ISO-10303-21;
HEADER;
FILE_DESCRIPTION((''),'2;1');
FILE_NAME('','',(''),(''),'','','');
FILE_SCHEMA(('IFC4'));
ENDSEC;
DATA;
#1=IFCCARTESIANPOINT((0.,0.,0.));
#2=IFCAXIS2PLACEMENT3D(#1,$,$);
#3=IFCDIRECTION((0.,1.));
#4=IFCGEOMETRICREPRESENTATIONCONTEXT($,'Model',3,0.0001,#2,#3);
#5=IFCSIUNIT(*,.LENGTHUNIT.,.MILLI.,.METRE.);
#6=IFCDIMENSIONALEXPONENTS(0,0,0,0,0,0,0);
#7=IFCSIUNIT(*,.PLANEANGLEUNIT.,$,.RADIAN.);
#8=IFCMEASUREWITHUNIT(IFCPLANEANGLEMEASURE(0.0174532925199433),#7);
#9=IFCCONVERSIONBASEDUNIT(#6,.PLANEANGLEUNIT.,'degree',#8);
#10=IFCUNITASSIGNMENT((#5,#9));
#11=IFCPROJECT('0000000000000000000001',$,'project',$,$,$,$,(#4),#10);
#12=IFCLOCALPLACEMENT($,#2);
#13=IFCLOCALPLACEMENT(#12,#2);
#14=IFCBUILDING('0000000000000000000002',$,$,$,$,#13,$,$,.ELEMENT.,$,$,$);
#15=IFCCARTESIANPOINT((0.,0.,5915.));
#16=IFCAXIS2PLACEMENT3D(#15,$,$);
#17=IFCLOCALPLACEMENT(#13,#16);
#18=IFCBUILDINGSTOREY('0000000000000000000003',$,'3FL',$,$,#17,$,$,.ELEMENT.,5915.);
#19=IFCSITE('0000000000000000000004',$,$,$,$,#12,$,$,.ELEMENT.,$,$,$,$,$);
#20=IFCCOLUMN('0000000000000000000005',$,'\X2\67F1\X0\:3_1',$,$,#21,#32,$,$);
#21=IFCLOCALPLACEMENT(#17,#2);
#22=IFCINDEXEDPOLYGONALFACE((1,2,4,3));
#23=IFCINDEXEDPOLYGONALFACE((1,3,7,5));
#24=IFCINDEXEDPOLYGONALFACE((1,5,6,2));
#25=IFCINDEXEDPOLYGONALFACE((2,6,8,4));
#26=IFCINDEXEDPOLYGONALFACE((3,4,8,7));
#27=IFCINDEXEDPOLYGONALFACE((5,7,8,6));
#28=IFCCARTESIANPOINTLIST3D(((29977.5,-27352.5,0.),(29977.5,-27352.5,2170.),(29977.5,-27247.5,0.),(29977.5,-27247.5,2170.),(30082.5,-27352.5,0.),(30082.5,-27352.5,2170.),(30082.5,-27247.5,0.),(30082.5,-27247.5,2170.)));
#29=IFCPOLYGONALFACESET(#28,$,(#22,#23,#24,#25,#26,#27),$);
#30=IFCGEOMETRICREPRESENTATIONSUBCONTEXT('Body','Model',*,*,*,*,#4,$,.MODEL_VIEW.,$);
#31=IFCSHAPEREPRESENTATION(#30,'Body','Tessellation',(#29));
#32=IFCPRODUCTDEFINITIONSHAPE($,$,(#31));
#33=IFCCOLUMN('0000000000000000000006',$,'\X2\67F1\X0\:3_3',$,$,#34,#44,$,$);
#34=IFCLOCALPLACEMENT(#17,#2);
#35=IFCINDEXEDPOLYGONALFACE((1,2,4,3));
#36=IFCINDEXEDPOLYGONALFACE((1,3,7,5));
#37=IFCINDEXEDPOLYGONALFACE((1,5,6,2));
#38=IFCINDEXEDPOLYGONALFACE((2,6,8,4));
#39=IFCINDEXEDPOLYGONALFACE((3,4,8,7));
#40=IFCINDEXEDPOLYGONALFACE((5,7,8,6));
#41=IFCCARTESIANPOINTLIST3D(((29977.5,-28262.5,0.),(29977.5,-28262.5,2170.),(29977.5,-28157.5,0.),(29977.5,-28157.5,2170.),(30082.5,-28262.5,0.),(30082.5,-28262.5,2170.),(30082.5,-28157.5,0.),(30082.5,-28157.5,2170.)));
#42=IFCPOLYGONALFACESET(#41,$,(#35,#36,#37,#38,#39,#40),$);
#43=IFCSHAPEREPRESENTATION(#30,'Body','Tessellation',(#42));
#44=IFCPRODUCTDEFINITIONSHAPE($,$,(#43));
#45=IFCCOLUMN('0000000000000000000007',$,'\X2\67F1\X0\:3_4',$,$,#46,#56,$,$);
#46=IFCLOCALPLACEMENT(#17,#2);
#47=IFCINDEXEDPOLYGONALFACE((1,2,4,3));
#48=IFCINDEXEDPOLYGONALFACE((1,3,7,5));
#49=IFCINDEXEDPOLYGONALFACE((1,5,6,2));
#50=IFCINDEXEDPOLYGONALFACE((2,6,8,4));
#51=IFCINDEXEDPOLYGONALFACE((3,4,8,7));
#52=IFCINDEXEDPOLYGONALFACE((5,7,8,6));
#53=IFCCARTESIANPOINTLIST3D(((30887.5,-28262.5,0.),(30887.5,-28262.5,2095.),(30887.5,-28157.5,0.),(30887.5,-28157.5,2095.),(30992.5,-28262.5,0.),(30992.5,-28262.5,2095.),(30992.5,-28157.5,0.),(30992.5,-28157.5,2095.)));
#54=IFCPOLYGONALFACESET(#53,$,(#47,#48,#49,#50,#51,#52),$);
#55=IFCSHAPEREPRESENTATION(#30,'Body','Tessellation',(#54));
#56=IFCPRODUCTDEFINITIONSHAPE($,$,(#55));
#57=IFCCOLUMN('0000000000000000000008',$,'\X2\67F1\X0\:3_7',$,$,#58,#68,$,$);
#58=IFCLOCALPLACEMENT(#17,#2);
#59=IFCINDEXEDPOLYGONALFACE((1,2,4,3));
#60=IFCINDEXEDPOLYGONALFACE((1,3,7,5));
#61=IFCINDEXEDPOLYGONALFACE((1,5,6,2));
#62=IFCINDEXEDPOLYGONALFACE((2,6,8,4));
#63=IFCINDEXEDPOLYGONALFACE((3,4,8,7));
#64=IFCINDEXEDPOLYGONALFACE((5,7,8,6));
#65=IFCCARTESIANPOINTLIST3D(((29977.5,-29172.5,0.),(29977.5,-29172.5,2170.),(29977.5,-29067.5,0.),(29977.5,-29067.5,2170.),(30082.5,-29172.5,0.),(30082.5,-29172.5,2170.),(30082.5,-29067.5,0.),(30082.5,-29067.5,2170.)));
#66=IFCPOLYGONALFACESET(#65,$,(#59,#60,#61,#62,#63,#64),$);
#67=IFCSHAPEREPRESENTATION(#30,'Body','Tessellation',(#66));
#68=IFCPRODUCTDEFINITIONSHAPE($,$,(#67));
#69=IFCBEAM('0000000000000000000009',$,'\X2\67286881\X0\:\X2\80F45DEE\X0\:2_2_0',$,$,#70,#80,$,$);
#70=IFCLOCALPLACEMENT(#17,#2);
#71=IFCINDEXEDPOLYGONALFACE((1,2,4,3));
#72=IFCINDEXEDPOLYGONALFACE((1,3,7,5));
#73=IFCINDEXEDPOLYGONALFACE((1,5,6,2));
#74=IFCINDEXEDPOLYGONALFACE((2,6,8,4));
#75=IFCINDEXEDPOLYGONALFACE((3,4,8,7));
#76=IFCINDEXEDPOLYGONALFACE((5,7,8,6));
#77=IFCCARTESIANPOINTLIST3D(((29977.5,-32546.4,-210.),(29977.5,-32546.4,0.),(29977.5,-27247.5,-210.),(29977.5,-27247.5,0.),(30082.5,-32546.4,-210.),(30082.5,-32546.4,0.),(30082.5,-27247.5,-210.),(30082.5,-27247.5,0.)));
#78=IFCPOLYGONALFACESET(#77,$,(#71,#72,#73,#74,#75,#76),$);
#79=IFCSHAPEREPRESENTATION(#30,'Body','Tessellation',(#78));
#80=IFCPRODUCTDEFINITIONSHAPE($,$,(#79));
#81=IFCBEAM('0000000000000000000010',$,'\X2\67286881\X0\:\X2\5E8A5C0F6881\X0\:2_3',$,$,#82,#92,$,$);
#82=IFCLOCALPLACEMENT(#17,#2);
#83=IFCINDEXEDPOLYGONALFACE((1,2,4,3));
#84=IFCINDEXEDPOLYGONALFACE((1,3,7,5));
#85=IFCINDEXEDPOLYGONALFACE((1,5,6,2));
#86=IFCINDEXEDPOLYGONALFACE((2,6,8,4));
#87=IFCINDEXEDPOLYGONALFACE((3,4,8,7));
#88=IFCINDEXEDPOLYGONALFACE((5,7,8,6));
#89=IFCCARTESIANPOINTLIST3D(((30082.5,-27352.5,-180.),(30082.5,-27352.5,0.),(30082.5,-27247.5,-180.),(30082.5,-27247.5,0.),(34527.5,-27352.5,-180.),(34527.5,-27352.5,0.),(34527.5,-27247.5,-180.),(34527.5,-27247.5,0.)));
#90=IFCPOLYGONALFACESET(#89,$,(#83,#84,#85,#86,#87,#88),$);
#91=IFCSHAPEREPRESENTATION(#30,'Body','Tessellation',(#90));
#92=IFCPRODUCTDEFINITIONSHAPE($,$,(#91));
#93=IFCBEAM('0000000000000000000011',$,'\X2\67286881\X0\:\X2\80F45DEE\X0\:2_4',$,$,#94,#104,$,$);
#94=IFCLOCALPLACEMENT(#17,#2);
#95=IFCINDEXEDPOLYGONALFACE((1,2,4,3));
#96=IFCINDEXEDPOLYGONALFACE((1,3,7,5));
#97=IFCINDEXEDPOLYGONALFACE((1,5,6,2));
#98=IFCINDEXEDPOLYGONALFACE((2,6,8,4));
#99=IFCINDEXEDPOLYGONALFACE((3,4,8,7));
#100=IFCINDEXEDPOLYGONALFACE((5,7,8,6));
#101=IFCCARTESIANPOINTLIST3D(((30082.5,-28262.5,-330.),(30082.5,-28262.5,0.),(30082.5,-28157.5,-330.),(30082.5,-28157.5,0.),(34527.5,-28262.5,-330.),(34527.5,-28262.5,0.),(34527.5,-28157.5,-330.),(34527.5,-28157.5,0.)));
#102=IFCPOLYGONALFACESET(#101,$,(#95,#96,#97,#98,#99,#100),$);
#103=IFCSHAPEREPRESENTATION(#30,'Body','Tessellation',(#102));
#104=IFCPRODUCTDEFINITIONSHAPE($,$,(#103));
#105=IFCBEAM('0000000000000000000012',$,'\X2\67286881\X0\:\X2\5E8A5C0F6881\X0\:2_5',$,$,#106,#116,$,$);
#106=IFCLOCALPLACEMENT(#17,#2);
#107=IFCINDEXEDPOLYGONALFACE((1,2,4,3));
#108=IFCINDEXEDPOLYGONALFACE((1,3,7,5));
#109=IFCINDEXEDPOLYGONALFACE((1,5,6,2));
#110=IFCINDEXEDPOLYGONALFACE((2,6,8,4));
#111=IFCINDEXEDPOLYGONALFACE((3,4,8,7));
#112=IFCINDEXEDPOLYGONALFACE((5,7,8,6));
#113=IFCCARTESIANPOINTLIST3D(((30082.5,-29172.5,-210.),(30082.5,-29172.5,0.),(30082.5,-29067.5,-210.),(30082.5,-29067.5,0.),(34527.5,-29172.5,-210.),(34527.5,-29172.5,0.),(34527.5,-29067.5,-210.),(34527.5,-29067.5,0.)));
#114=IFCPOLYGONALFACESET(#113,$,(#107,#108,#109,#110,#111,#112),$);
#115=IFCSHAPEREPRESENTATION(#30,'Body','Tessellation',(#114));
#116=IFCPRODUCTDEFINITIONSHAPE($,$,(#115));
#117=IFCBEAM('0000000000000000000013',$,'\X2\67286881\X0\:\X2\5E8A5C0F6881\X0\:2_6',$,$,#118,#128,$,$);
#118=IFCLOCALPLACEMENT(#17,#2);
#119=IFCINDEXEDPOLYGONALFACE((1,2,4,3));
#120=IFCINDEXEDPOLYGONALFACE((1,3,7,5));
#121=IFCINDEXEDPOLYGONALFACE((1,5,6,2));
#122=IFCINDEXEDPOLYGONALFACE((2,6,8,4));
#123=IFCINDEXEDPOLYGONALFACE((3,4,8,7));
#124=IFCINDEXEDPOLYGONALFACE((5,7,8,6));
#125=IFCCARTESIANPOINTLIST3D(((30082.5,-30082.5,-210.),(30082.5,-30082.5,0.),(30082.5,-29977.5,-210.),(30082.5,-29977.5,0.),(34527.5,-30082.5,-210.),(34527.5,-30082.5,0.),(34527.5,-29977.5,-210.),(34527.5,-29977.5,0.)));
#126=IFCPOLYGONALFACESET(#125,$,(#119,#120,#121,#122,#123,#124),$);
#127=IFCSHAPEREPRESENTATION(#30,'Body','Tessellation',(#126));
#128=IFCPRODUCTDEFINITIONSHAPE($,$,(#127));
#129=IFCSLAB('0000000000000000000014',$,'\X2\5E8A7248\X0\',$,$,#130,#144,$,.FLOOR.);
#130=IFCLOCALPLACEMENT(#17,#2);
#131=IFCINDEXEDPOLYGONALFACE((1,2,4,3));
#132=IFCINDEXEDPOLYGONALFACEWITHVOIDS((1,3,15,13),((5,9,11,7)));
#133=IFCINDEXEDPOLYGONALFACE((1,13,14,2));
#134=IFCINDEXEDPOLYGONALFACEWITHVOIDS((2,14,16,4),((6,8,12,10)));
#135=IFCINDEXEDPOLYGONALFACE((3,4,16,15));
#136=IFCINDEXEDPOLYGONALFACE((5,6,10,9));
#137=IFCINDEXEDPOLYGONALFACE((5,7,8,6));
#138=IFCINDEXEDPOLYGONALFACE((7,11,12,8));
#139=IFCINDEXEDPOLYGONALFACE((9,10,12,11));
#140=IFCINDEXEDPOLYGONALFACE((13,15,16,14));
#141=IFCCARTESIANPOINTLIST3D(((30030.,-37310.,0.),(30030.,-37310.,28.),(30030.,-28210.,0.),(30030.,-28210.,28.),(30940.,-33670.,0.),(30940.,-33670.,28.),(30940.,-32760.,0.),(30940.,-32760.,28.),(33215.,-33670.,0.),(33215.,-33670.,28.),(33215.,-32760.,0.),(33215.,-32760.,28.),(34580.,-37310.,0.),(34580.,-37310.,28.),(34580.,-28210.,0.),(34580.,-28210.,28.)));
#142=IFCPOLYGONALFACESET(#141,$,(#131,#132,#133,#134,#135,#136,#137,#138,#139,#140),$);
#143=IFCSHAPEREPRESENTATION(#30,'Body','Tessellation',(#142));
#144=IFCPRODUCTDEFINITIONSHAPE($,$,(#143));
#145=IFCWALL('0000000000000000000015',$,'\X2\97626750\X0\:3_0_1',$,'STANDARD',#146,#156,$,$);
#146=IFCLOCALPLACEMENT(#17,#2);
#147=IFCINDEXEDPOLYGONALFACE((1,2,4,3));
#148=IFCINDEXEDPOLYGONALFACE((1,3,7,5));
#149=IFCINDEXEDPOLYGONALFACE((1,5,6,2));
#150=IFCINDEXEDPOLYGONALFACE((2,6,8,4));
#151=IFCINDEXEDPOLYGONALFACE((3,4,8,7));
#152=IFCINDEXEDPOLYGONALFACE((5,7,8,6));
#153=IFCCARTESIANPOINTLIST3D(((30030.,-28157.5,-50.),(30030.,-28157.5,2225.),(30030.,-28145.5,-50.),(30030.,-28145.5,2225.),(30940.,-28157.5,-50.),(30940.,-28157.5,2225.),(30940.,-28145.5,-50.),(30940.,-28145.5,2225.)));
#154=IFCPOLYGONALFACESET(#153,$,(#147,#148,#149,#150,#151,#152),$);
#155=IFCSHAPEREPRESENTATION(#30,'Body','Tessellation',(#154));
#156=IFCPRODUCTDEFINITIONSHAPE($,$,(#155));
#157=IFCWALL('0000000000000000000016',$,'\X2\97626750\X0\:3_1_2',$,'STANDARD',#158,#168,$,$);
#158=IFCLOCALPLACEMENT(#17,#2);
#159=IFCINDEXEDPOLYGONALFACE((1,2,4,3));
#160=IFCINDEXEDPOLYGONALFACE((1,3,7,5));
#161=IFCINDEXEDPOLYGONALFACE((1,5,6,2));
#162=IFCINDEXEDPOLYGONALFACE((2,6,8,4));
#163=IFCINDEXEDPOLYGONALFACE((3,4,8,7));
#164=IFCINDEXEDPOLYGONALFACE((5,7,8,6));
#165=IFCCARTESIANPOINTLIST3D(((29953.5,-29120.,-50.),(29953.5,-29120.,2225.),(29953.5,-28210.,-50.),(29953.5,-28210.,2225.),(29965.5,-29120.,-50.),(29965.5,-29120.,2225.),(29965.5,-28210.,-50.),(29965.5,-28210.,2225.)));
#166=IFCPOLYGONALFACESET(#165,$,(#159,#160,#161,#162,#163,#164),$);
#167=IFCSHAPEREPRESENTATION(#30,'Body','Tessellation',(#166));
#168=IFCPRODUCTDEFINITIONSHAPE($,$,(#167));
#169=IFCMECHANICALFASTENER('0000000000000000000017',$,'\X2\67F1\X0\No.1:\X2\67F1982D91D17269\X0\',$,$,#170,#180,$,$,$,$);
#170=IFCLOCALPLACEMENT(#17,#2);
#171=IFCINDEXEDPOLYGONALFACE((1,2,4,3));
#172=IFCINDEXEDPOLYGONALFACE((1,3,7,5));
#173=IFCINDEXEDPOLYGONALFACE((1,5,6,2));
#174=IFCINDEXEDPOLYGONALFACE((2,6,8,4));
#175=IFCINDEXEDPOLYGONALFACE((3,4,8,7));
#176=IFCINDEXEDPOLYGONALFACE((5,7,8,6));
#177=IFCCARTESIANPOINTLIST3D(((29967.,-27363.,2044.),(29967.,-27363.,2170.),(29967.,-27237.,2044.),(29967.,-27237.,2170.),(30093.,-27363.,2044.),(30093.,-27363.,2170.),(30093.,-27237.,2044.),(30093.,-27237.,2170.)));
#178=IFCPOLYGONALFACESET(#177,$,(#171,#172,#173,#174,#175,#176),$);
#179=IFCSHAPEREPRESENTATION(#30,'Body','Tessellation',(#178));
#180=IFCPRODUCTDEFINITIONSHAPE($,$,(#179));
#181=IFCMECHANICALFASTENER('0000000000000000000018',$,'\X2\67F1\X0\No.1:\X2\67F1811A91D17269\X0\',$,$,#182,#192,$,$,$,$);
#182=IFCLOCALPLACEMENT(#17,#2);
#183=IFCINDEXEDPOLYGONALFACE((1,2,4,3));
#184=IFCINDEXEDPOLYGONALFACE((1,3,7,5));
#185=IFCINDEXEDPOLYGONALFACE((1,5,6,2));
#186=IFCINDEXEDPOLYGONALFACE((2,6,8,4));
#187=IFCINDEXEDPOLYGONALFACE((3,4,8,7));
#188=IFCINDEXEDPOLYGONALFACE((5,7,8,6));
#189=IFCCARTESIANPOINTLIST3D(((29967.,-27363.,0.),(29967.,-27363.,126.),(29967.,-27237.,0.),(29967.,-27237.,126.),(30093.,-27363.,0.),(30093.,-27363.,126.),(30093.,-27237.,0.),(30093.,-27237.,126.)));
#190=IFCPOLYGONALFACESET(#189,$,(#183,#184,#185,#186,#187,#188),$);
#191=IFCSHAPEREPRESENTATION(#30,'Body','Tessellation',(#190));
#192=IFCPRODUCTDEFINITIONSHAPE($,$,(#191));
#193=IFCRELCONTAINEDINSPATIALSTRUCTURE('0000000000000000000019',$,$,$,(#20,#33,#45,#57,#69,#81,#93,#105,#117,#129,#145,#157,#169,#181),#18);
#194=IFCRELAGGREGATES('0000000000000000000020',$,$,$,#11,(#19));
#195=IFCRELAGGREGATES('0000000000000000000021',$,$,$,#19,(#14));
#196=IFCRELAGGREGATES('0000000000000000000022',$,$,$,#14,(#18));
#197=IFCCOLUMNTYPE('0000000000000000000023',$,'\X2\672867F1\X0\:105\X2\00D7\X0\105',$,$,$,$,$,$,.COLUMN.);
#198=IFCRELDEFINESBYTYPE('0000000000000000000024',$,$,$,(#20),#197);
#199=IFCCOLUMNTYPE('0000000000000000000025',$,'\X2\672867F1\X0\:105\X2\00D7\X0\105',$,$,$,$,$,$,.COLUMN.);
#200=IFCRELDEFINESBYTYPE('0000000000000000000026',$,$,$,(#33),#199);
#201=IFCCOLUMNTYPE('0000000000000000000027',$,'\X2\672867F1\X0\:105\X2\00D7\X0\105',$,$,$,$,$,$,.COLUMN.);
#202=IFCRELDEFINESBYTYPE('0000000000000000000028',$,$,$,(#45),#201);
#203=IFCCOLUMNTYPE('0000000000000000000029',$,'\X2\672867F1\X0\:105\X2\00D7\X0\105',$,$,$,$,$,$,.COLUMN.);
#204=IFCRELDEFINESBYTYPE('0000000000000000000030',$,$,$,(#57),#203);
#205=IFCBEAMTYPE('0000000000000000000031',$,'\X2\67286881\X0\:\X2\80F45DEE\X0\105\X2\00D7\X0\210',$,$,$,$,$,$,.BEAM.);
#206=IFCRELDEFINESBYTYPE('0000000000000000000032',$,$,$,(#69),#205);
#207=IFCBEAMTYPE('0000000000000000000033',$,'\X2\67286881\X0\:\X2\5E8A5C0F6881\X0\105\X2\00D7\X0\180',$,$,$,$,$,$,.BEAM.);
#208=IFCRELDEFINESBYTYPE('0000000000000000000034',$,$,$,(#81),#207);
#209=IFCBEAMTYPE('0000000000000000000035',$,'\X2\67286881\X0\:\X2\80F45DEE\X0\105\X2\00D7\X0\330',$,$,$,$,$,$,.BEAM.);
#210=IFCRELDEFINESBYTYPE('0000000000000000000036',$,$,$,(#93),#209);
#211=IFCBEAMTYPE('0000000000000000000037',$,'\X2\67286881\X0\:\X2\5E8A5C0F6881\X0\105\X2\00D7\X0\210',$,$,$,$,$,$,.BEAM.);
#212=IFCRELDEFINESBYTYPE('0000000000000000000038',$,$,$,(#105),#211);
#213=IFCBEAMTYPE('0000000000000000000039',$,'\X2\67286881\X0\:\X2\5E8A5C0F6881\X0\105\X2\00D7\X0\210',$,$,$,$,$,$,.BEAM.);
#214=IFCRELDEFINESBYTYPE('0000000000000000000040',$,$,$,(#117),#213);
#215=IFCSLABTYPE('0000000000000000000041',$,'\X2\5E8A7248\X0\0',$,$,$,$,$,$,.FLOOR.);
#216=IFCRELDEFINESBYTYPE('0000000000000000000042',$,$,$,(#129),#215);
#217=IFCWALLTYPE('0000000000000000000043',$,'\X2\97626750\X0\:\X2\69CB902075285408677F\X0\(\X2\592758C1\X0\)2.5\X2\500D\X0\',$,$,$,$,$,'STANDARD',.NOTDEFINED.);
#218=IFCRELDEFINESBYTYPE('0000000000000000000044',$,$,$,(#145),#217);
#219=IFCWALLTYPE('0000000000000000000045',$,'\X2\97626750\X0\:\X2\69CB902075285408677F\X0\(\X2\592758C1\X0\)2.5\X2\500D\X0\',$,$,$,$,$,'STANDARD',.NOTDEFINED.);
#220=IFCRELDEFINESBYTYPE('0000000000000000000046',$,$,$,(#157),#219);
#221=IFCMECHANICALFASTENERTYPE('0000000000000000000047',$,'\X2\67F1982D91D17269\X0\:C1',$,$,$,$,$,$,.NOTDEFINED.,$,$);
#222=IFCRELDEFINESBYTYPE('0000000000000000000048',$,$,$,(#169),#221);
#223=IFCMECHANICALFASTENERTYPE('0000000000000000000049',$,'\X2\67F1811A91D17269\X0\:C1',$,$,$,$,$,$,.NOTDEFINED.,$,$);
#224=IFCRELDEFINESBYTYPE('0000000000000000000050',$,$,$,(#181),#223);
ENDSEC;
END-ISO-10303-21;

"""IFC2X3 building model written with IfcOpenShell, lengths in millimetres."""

from ifc_helpers import new_model, entity, si_unit, converted_unit, direction, frame, origin, origin_with_axes, origin_2d, place, context, subcontext, project, spatial, polyline, rectangle, outline, extrude, type_object, element, save


model = new_model("IFC2X3")

# Units and contexts
model_context = context("Model", 3, precision=0.0001, world=origin(), true_north=direction((0.0, 1.0)))
body_context = subcontext(model_context, "Body", "Model", "MODEL_VIEW")
ifc_project = project(units=[si_unit("LENGTHUNIT", "METRE", prefix="MILLI"), converted_unit("PLANEANGLEUNIT", "degree", entity("IfcPlaneAngleMeasure", 0.0174532925199433), si_unit("PLANEANGLEUNIT", "RADIAN"), dimensions=[0, 0, 0, 0, 0, 0, 0])], contexts=[model_context])

# Site, building, storey
site_placement = place(None, origin())
site = spatial("IfcSite", under=ifc_project, at=site_placement, CompositionType="ELEMENT")
building_placement = place(site_placement, origin())
building = spatial("IfcBuilding", under=site, at=building_placement, CompositionType="ELEMENT")
storey_placement = place(building_placement, frame((0.0, 0.0, 5915.0)))
storey = spatial("IfcBuildingStorey", under=building, at=storey_placement, Name="3FL", CompositionType="ELEMENT", Elevation=5915.0)

# Columns
column_type_1 = type_object("IfcColumnType", Name="木柱:105×105", PredefinedType="COLUMN")
column_1_placement = place(storey_placement, frame((30030.0, -27300.0, 0.0)))
element("IfcColumn", 1, at=column_1_placement, inside=storey, type_object=column_type_1, Name="柱:3_1", context=body_context, shape_type="SweptSolid", body=[
    extrude(rectangle(XDim=105.0, YDim=105.0, at=origin_2d()), origin_with_axes(), (0.0, 0.0, 1.0), 2170.0),
])
column_type_2 = type_object("IfcColumnType", Name="木柱:105×105", PredefinedType="COLUMN")
column_2_placement = place(storey_placement, frame((30030.0, -28210.0, 0.0)))
element("IfcColumn", 2, at=column_2_placement, inside=storey, type_object=column_type_2, Name="柱:3_3", context=body_context, shape_type="SweptSolid", body=[
    extrude(rectangle(XDim=105.0, YDim=105.0, at=origin_2d()), origin_with_axes(), (0.0, 0.0, 1.0), 2170.0),
])
column_type_3 = type_object("IfcColumnType", Name="木柱:105×105", PredefinedType="COLUMN")
column_3_placement = place(storey_placement, frame((30940.0, -28210.0, 0.0)))
element("IfcColumn", 3, at=column_3_placement, inside=storey, type_object=column_type_3, Name="柱:3_4", context=body_context, shape_type="SweptSolid", body=[
    extrude(rectangle(XDim=105.0, YDim=105.0, at=origin_2d()), origin_with_axes(), (0.0, 0.0, 1.0), 2095.0),
])
column_type_4 = type_object("IfcColumnType", Name="木柱:105×105", PredefinedType="COLUMN")
column_4_placement = place(storey_placement, frame((30030.0, -29120.0, 0.0)))
element("IfcColumn", 4, at=column_4_placement, inside=storey, type_object=column_type_4, Name="柱:3_7", context=body_context, shape_type="SweptSolid", body=[
    extrude(rectangle(XDim=105.0, YDim=105.0, at=origin_2d()), origin_with_axes(), (0.0, 0.0, 1.0), 2170.0),
])

# Beams
beam_type_1 = type_object("IfcBeamType", Name="木梁:胴差105×210", PredefinedType="BEAM")
beam_1_placement = place(storey_placement, frame((30030.0, -27247.5, -105.0), z_axis=(0.0, -1.0, 0.0), x_axis=(1.0, 0.0, 0.0)))
element("IfcBeam", 5, at=beam_1_placement, inside=storey, type_object=beam_type_1, Name="木梁:胴差:2_2_0", context=body_context, shape_type="SweptSolid", body=[
    extrude(rectangle(XDim=105.0, YDim=210.0, at=origin_2d()), origin_with_axes(), (0.0, 0.0, 1.0), 5298.9),
])
beam_type_2 = type_object("IfcBeamType", Name="木梁:床小梁105×180", PredefinedType="BEAM")
beam_2_placement = place(storey_placement, frame((30082.5, -27300.0, -90.0), z_axis=(1.0, 0.0, 0.0), x_axis=(0.0, 1.0, 0.0)))
element("IfcBeam", 6, at=beam_2_placement, inside=storey, type_object=beam_type_2, Name="木梁:床小梁:2_3", context=body_context, shape_type="SweptSolid", body=[
    extrude(rectangle(XDim=105.0, YDim=180.0, at=origin_2d()), origin_with_axes(), (0.0, 0.0, 1.0), 4445.0),
])
beam_type_3 = type_object("IfcBeamType", Name="木梁:胴差105×330", PredefinedType="BEAM")
beam_3_placement = place(storey_placement, frame((30082.5, -28210.0, -165.0), z_axis=(1.0, 0.0, 0.0), x_axis=(0.0, 1.0, 0.0)))
element("IfcBeam", 7, at=beam_3_placement, inside=storey, type_object=beam_type_3, Name="木梁:胴差:2_4", context=body_context, shape_type="SweptSolid", body=[
    extrude(rectangle(XDim=105.0, YDim=330.0, at=origin_2d()), origin_with_axes(), (0.0, 0.0, 1.0), 4445.0),
])
beam_type_4 = type_object("IfcBeamType", Name="木梁:床小梁105×210", PredefinedType="BEAM")
beam_4_placement = place(storey_placement, frame((30082.5, -29120.0, -105.0), z_axis=(1.0, 0.0, 0.0), x_axis=(0.0, 1.0, 0.0)))
element("IfcBeam", 8, at=beam_4_placement, inside=storey, type_object=beam_type_4, Name="木梁:床小梁:2_5", context=body_context, shape_type="SweptSolid", body=[
    extrude(rectangle(XDim=105.0, YDim=210.0, at=origin_2d()), origin_with_axes(), (0.0, 0.0, 1.0), 4445.0),
])
beam_type_5 = type_object("IfcBeamType", Name="木梁:床小梁105×210", PredefinedType="BEAM")
beam_5_placement = place(storey_placement, frame((30082.5, -30030.0, -105.0), z_axis=(1.0, 0.0, 0.0), x_axis=(0.0, 1.0, 0.0)))
element("IfcBeam", 9, at=beam_5_placement, inside=storey, type_object=beam_type_5, Name="木梁:床小梁:2_6", context=body_context, shape_type="SweptSolid", body=[
    extrude(rectangle(XDim=105.0, YDim=210.0, at=origin_2d()), origin_with_axes(), (0.0, 0.0, 1.0), 4445.0),
])

# Slab
slab_type = type_object("IfcSlabType", Name="床版0", PredefinedType="FLOOR")
slab_placement = place(storey_placement, origin_with_axes())
element("IfcSlab", 10, at=slab_placement, inside=storey, type_object=slab_type, Name="床版", PredefinedType="FLOOR", context=body_context, shape_type="SweptSolid", body=[
    extrude(outline(polyline([(30030.0, -28210.0, 0.0), (30030.0, -37310.0, 0.0), (34580.0, -37310.0, 0.0), (34580.0, -28210.0, 0.0), (30030.0, -28210.0, 0.0)]), holes=[polyline([(30940.0, -33670.0, 0.0), (33215.0, -33670.0, 0.0), (33215.0, -32760.0, 0.0), (30940.0, -32760.0, 0.0), (30940.0, -33670.0, 0.0)])]), origin_with_axes(), (0.0, 0.0, 1.0), 28.0),
])

# Walls
wall_type_1 = type_object("IfcWallType", Name="面材:構造用合板(大壁)2.5倍", ElementType="STANDARD", PredefinedType="NOTDEFINED")
wall_1_placement = place(storey_placement, frame((30485.0, -28145.5, -50.0), z_axis=(0.0, -1.0, 0.0), x_axis=(1.0, 0.0, 0.0)))
element("IfcWall", 11, at=wall_1_placement, inside=storey, type_object=wall_type_1, Name="面材:3_0_1", ObjectType="STANDARD", context=body_context, shape_type="SweptSolid", body=[
    extrude(outline(polyline([(455.0, 0.0, 0.0), (-455.0, 0.0, 0.0), (-455.0, 2275.0, 0.0), (455.0, 2275.0, 0.0), (455.0, 0.0, 0.0)])), origin_with_axes(), (0.0, 0.0, 1.0), 12.0),
])
wall_type_2 = type_object("IfcWallType", Name="面材:構造用合板(大壁)2.5倍", ElementType="STANDARD", PredefinedType="NOTDEFINED")
wall_2_placement = place(storey_placement, frame((29965.5, -28665.0, -50.0), z_axis=(-1.0, 0.0, 0.0), x_axis=(0.0, -1.0, 0.0)))
element("IfcWall", 12, at=wall_2_placement, inside=storey, type_object=wall_type_2, Name="面材:3_1_2", ObjectType="STANDARD", context=body_context, shape_type="SweptSolid", body=[
    extrude(outline(polyline([(455.0, 0.0, 0.0), (-455.0, 0.0, 0.0), (-455.0, 2275.0, 0.0), (455.0, 2275.0, 0.0), (455.0, 0.0, 0.0)])), origin_with_axes(), (0.0, 0.0, 1.0), 12.0),
])

# Mechanical fasteners
mechanical_fastener_type_1 = type_object("IfcMechanicalFastenerType", Name="柱頭金物:C1")
mechanical_fastener_1_placement = place(storey_placement, frame((30030.0, -27300.0, 2044.0)))
element("IfcMechanicalFastener", 13, at=mechanical_fastener_1_placement, inside=storey, type_object=mechanical_fastener_type_1, Name="柱No.1:柱頭金物", context=body_context, shape_type="SweptSolid", body=[
    extrude(rectangle(XDim=126.0, YDim=126.0, at=origin_2d()), origin_with_axes(), (0.0, 0.0, 1.0), 126.0),
])
mechanical_fastener_type_2 = type_object("IfcMechanicalFastenerType", Name="柱脚金物:C1")
mechanical_fastener_2_placement = place(storey_placement, frame((30030.0, -27300.0, 0.0)))
element("IfcMechanicalFastener", 14, at=mechanical_fastener_2_placement, inside=storey, type_object=mechanical_fastener_type_2, Name="柱No.1:柱脚金物", context=body_context, shape_type="SweptSolid", body=[
    extrude(rectangle(XDim=126.0, YDim=126.0, at=origin_2d()), origin_with_axes(), (0.0, 0.0, 1.0), 126.0),
])

save(model, "model.ifc")
